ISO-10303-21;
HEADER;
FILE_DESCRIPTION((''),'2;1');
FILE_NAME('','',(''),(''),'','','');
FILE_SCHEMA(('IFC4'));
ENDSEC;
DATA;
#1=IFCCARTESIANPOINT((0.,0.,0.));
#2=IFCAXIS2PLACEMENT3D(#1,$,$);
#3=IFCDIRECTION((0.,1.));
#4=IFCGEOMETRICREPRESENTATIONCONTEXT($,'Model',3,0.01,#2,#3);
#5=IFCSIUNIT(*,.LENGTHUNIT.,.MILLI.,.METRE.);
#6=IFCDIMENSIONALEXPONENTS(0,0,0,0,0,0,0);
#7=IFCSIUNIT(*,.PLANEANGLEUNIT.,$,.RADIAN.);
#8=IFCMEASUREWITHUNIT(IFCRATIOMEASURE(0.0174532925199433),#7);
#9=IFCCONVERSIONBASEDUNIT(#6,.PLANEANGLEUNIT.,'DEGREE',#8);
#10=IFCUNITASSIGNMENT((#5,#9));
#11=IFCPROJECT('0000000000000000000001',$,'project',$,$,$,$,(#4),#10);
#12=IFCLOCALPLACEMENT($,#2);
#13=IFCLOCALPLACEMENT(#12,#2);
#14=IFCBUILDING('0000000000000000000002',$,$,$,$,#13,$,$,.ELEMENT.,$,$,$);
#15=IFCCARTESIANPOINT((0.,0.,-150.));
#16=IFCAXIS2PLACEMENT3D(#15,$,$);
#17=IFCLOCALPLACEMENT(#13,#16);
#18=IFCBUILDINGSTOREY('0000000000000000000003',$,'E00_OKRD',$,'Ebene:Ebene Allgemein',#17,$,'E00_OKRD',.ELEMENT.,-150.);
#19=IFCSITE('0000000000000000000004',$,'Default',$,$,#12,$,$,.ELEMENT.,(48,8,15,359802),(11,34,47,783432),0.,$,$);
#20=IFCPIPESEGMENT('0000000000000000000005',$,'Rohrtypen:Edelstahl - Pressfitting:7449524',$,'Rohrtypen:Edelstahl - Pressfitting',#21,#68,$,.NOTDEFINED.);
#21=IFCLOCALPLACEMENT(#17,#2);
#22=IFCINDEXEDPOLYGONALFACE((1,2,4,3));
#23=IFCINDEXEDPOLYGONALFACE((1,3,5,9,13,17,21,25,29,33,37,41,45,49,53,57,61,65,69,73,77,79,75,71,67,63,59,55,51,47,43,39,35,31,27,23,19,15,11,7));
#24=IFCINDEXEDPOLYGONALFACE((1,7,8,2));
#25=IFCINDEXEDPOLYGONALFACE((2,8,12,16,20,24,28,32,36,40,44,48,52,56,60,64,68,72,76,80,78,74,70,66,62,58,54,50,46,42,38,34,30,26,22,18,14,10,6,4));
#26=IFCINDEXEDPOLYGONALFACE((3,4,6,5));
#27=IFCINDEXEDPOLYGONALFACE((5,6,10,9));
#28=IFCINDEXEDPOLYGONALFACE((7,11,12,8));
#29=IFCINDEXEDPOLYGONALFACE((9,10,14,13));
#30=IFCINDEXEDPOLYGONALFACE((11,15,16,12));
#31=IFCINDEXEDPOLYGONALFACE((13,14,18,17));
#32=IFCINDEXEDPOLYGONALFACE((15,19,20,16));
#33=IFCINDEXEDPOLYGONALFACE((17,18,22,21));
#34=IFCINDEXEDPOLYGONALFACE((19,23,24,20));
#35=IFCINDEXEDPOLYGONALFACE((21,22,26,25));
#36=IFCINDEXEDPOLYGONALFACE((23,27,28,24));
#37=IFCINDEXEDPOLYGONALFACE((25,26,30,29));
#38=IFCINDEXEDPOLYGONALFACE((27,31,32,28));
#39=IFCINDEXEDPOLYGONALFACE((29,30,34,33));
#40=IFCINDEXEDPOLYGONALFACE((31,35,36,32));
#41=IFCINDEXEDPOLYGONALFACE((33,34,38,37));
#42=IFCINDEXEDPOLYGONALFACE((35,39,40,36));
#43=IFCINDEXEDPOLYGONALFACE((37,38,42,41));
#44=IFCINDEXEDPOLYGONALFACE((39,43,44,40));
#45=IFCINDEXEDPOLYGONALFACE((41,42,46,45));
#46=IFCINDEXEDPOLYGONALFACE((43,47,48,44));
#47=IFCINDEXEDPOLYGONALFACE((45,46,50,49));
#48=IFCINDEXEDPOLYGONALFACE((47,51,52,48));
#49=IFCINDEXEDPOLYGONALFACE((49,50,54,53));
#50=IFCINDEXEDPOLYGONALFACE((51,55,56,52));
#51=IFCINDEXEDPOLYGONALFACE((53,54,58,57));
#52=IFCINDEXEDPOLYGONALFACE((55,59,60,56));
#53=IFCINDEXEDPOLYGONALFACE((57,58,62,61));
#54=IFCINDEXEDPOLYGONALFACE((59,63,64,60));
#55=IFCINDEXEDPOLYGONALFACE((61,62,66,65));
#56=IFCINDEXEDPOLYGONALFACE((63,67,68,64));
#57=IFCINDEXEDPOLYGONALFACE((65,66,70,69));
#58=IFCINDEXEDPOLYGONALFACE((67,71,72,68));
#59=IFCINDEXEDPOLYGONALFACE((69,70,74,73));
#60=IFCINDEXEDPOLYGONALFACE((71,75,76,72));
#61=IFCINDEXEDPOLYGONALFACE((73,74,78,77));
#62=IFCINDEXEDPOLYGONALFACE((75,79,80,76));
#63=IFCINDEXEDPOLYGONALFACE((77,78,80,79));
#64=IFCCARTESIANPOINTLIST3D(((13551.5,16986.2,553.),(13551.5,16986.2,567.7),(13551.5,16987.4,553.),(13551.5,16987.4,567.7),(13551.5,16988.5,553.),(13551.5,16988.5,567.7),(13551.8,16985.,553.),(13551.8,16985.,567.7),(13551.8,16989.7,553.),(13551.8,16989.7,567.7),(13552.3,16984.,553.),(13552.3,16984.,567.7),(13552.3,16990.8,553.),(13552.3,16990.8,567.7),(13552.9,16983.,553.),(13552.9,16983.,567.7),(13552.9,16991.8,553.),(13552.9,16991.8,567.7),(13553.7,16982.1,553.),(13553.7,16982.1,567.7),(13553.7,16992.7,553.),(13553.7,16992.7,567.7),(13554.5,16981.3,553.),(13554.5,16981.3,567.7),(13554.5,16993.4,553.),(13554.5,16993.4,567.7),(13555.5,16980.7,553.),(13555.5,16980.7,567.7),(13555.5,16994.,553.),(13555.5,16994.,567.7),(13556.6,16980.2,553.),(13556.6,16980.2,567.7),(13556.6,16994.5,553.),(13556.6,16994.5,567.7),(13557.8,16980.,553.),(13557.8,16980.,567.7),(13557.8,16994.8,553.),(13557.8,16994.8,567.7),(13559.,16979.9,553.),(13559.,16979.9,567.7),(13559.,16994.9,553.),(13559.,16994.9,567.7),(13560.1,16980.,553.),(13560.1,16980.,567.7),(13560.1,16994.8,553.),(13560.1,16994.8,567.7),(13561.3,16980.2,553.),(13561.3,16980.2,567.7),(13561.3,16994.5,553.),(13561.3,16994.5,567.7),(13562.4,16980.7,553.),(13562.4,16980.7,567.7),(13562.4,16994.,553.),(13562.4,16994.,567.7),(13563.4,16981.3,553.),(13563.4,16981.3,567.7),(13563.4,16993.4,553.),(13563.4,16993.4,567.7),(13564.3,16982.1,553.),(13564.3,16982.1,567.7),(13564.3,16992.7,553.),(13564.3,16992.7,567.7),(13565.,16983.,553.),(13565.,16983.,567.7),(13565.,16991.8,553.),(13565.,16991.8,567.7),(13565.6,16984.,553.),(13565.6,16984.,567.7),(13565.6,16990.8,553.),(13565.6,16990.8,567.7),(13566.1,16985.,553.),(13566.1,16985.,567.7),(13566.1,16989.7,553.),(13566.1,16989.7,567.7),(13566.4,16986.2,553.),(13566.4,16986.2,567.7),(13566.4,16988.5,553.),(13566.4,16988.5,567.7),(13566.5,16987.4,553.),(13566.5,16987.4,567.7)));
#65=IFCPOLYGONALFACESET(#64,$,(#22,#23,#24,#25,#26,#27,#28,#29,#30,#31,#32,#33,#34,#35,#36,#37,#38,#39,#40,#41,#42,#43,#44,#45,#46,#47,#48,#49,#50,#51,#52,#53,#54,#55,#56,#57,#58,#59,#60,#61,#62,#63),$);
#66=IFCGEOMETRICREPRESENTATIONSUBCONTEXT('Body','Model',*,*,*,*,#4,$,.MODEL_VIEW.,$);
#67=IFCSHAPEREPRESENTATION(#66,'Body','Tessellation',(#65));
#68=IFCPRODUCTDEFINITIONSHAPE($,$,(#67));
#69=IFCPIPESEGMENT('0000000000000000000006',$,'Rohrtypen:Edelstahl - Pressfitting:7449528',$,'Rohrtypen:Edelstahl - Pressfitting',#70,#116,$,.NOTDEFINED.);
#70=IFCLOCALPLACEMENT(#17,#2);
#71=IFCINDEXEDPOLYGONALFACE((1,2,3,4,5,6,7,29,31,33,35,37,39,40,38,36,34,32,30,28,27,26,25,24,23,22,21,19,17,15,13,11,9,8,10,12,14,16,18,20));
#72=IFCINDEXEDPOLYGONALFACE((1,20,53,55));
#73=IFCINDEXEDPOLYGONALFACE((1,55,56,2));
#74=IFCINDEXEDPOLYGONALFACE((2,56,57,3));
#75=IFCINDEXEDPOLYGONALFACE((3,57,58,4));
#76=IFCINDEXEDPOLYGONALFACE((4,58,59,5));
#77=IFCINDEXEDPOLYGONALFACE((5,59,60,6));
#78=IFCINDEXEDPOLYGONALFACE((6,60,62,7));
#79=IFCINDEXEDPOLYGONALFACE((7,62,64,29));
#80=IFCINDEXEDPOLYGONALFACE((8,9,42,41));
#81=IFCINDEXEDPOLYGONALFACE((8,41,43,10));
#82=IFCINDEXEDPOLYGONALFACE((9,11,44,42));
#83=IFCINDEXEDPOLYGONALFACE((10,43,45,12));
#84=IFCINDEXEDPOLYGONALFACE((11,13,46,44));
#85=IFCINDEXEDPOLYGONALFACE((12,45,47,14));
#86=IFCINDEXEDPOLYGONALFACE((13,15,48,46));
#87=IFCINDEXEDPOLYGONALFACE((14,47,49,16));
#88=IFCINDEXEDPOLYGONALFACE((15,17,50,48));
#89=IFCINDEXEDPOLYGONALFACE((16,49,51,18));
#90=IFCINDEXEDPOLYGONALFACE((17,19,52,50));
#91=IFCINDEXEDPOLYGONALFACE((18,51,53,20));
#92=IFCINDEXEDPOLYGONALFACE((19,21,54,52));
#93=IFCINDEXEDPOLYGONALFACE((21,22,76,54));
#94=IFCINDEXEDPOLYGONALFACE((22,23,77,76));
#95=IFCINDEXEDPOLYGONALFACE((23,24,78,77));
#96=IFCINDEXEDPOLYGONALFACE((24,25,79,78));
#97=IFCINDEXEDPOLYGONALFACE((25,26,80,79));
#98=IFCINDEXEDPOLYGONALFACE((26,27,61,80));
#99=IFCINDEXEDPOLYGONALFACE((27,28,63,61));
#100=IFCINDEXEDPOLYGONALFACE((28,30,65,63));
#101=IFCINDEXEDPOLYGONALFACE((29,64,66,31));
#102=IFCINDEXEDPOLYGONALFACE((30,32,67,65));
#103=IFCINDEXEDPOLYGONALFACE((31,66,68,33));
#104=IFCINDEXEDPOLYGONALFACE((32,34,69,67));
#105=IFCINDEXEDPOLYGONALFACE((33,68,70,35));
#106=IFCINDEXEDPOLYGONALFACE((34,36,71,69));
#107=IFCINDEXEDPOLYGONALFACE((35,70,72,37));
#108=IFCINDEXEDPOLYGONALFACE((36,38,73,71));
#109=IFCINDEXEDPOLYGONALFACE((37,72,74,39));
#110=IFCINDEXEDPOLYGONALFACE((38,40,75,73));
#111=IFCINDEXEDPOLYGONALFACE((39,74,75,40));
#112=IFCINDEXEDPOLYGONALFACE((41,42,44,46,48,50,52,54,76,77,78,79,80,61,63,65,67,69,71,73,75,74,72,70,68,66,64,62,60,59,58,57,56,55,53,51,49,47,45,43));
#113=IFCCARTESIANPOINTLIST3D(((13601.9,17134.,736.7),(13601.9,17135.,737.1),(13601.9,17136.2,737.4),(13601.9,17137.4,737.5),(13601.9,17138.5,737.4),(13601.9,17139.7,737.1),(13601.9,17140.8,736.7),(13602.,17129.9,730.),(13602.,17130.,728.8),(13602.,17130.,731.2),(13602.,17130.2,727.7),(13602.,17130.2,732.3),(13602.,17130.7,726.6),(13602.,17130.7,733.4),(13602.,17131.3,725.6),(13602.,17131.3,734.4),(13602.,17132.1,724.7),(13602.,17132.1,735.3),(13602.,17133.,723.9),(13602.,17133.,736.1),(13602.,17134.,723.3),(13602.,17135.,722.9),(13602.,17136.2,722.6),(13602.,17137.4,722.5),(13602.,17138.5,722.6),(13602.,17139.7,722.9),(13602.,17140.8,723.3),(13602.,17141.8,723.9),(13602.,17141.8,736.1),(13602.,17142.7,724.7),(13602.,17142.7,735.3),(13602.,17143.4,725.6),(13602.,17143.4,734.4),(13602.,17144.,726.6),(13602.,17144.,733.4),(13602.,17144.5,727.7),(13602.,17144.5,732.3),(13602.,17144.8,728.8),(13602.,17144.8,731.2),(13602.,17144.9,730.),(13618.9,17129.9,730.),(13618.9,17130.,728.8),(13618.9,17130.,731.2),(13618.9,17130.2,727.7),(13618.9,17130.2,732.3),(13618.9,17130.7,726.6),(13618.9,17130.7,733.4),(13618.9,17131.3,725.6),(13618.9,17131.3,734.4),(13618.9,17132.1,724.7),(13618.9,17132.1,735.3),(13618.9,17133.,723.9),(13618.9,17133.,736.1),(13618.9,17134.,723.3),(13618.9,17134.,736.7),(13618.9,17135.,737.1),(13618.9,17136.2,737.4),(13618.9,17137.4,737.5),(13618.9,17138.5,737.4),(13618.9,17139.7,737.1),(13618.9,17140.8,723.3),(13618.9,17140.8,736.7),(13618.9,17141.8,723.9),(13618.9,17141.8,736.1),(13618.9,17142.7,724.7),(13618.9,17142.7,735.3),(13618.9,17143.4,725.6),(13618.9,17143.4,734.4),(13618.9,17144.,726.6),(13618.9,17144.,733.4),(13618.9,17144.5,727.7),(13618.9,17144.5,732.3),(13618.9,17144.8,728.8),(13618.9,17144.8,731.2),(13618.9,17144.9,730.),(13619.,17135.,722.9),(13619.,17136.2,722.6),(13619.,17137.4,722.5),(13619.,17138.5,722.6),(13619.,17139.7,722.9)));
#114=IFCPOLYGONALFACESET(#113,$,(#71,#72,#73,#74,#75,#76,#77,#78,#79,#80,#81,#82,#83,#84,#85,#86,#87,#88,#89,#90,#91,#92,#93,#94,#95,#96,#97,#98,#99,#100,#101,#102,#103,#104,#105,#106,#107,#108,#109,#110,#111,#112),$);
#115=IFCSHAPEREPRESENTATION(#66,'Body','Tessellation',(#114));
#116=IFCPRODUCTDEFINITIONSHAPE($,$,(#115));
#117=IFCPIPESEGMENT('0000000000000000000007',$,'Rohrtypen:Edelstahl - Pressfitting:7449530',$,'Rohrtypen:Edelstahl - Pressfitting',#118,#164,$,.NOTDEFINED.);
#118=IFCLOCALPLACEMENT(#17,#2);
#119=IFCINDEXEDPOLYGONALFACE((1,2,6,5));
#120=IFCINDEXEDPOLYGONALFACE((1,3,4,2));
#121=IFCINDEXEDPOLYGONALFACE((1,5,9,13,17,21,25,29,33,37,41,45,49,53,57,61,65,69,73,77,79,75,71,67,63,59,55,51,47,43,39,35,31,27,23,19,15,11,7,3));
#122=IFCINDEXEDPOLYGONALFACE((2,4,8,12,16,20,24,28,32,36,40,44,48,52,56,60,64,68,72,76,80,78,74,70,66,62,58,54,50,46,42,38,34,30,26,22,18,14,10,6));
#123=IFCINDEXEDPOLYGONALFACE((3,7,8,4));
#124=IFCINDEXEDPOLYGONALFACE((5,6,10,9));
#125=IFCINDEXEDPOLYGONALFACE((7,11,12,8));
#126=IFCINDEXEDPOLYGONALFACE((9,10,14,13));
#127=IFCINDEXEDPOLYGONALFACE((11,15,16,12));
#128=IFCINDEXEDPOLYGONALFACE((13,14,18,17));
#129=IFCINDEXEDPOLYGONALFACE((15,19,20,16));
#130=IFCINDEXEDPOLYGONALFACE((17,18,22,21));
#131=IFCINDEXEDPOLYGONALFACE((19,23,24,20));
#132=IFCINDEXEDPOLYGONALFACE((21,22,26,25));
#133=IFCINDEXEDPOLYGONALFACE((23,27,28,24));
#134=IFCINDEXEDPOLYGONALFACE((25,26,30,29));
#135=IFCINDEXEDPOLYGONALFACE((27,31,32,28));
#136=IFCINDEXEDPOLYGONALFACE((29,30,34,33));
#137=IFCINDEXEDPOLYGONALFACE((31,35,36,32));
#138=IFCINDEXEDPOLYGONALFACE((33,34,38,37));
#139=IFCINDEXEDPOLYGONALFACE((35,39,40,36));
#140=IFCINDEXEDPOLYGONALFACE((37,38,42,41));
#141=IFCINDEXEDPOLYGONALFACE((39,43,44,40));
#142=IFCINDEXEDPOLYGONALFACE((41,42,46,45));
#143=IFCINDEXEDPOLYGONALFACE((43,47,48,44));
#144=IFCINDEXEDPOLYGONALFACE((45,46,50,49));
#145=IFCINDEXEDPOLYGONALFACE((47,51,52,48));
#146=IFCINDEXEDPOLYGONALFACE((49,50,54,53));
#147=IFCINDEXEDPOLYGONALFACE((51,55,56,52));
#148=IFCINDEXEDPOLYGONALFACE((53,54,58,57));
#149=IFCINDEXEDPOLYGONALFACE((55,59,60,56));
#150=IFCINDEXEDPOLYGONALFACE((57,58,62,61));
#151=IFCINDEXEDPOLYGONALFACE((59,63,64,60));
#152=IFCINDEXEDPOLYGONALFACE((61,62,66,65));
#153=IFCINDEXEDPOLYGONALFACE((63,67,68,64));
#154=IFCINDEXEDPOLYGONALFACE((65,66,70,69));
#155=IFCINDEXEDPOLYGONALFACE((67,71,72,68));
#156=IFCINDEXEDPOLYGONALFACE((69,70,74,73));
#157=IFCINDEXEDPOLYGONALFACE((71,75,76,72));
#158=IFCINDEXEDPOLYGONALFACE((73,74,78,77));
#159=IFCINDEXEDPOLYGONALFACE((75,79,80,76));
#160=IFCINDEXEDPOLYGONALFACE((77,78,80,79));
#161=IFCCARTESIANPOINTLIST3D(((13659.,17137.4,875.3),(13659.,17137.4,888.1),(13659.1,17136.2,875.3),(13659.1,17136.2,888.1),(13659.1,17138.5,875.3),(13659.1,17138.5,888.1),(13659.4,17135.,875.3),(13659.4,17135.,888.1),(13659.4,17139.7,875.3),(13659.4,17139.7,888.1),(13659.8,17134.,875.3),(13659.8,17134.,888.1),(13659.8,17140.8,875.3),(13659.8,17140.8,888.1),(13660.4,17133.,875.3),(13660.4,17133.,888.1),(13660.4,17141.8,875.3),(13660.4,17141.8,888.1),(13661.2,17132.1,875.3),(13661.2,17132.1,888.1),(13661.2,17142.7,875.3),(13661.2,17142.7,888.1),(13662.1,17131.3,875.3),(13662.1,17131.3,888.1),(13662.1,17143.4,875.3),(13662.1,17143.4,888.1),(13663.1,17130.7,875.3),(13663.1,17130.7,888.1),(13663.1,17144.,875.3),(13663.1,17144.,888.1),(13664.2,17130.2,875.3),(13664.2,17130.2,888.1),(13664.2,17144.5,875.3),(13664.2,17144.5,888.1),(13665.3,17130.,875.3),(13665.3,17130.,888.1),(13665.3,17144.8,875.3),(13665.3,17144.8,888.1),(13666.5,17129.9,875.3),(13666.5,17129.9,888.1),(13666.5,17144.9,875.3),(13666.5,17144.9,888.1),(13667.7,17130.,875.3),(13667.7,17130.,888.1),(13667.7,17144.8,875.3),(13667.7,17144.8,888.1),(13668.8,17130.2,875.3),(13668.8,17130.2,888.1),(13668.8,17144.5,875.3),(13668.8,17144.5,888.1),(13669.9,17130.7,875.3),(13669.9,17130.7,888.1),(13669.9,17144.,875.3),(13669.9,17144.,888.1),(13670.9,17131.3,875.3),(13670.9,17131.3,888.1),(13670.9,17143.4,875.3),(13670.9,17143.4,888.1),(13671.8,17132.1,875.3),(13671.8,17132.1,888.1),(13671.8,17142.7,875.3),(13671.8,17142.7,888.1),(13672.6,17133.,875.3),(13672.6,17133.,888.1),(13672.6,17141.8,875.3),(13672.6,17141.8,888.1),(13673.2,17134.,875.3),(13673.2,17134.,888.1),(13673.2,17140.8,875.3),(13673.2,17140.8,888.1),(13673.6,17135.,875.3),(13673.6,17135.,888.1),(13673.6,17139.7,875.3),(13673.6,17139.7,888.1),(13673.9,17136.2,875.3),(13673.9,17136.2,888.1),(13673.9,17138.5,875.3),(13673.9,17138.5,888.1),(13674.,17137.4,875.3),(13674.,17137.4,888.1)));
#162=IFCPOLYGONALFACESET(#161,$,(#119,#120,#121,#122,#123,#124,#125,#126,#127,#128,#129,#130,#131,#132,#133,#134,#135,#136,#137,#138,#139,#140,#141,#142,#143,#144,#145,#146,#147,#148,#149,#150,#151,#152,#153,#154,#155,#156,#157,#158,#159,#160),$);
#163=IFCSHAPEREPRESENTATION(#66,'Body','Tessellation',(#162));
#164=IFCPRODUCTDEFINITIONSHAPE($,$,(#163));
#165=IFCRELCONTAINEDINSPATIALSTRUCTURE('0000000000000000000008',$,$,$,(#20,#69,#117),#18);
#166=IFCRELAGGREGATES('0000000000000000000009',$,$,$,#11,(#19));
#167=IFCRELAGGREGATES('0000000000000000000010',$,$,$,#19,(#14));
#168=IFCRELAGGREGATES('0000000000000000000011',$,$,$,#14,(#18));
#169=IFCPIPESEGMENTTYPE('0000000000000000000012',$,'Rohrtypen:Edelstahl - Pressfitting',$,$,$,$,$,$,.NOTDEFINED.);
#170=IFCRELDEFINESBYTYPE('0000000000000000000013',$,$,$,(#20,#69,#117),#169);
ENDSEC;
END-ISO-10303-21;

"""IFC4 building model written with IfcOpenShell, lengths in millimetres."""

from ifc_helpers import new_model, entity, si_unit, converted_unit, direction, frame, origin, place, context, subcontext, project, spatial, indexed_curve, outline, extrude, type_object, element, save


model = new_model("IFC4")

# Units and contexts
model_context = context("Model", 3, precision=0.01, world=origin(), true_north=direction((0.0, 1.0)))
body_context = subcontext(model_context, "Body", "Model", "MODEL_VIEW")
ifc_project = project(units=[si_unit("LENGTHUNIT", "METRE", prefix="MILLI"), converted_unit("PLANEANGLEUNIT", "DEGREE", entity("IfcRatioMeasure", 0.0174532925199433), si_unit("PLANEANGLEUNIT", "RADIAN"), dimensions=[0, 0, 0, 0, 0, 0, 0])], contexts=[model_context])

# Site, building, storey
site_placement = place(None, origin())
site = spatial("IfcSite", under=ifc_project, at=site_placement, Name="Default", CompositionType="ELEMENT", RefLatitude=(48, 8, 15, 359802), RefLongitude=(11, 34, 47, 783432), RefElevation=0.0)
building_placement = place(site_placement, origin())
building = spatial("IfcBuilding", under=site, at=building_placement, CompositionType="ELEMENT")
storey_placement = place(building_placement, frame((0.0, 0.0, -150.0)))
storey = spatial("IfcBuildingStorey", under=building, at=storey_placement, Name="E00_OKRD", ObjectType="Ebene:Ebene Allgemein", LongName="E00_OKRD", CompositionType="ELEMENT", Elevation=-150.0)

# Pipe segments
pipe_segment_type_1 = type_object("IfcPipeSegmentType", Name="Rohrtypen:Edelstahl - Pressfitting", PredefinedType="NOTDEFINED")
pipe_segment_1_placement = place(storey_placement, origin())
element("IfcPipeSegment", 1, at=pipe_segment_1_placement, inside=storey, type_object=pipe_segment_type_1, Name="Rohrtypen:Edelstahl - Pressfitting:7449524", ObjectType="Rohrtypen:Edelstahl - Pressfitting", PredefinedType="NOTDEFINED", context=body_context, shape_type="SweptSolid", body=[
    extrude(outline(indexed_curve([(7.5, 0.0), (7.4, 1.2), (7.1, 2.3), (6.7, 3.4), (6.1, 4.4), (5.3, 5.3), (4.4, 6.1), (3.4, 6.7), (2.3, 7.1), (1.2, 7.4), (0.0, 7.5), (-1.2, 7.4), (-2.3, 7.1), (-3.4, 6.7), (-4.4, 6.1), (-5.3, 5.3), (-6.1, 4.4), (-6.7, 3.4), (-7.1, 2.3), (-7.4, 1.2), (-7.5, 0.0), (-7.4, -1.2), (-7.1, -2.3), (-6.7, -3.4), (-6.1, -4.4), (-5.3, -5.3), (-4.4, -6.1), (-3.4, -6.7), (-2.3, -7.1), (-1.2, -7.4), (0.0, -7.5), (1.2, -7.4), (2.3, -7.1), (3.4, -6.7), (4.4, -6.1), (5.3, -5.3), (6.1, -4.4), (6.7, -3.4), (7.1, -2.3), (7.4, -1.2), (7.5, 0.0)], self_intersect=False)), frame((13559.0, 16987.4, 553.0)), (0.0, 0.0, 1.0), 14.7),
])
pipe_segment_2_placement = place(storey_placement, origin())
element("IfcPipeSegment", 2, at=pipe_segment_2_placement, inside=storey, type_object=pipe_segment_type_1, Name="Rohrtypen:Edelstahl - Pressfitting:7449528", ObjectType="Rohrtypen:Edelstahl - Pressfitting", PredefinedType="NOTDEFINED", context=body_context, shape_type="SweptSolid", body=[
    extrude(outline(indexed_curve([(7.5, 0.0), (7.4, 1.2), (7.1, 2.3), (6.7, 3.4), (6.1, 4.4), (5.3, 5.3), (4.4, 6.1), (3.4, 6.7), (2.3, 7.1), (1.2, 7.4), (0.0, 7.5), (-1.2, 7.4), (-2.3, 7.1), (-3.4, 6.7), (-4.4, 6.1), (-5.3, 5.3), (-6.1, 4.4), (-6.7, 3.4), (-7.1, 2.3), (-7.4, 1.2), (-7.5, 0.0), (-7.4, -1.2), (-7.1, -2.3), (-6.7, -3.4), (-6.1, -4.4), (-5.3, -5.3), (-4.4, -6.1), (-3.4, -6.7), (-2.3, -7.1), (-1.2, -7.4), (0.0, -7.5), (1.2, -7.4), (2.3, -7.1), (3.4, -6.7), (4.4, -6.1), (5.3, -5.3), (6.1, -4.4), (6.7, -3.4), (7.1, -2.3), (7.4, -1.2), (7.5, 0.0)], self_intersect=False)), frame((13602.0, 17137.4, 730.0), z_axis=(1.0, 0.0, 0.00053), x_axis=(0.0, -1.0, 0.0)), (0.0, 0.0, 1.0), 17.0),
])
pipe_segment_3_placement = place(storey_placement, origin())
element("IfcPipeSegment", 3, at=pipe_segment_3_placement, inside=storey, type_object=pipe_segment_type_1, Name="Rohrtypen:Edelstahl - Pressfitting:7449530", ObjectType="Rohrtypen:Edelstahl - Pressfitting", PredefinedType="NOTDEFINED", context=body_context, shape_type="SweptSolid", body=[
    extrude(outline(indexed_curve([(7.5, 0.0), (7.4, 1.2), (7.1, 2.3), (6.7, 3.4), (6.1, 4.4), (5.3, 5.3), (4.4, 6.1), (3.4, 6.7), (2.3, 7.1), (1.2, 7.4), (0.0, 7.5), (-1.2, 7.4), (-2.3, 7.1), (-3.4, 6.7), (-4.4, 6.1), (-5.3, 5.3), (-6.1, 4.4), (-6.7, 3.4), (-7.1, 2.3), (-7.4, 1.2), (-7.5, 0.0), (-7.4, -1.2), (-7.1, -2.3), (-6.7, -3.4), (-6.1, -4.4), (-5.3, -5.3), (-4.4, -6.1), (-3.4, -6.7), (-2.3, -7.1), (-1.2, -7.4), (0.0, -7.5), (1.2, -7.4), (2.3, -7.1), (3.4, -6.7), (4.4, -6.1), (5.3, -5.3), (6.1, -4.4), (6.7, -3.4), (7.1, -2.3), (7.4, -1.2), (7.5, 0.0)], self_intersect=False)), frame((13666.5, 17137.4, 875.3), z_axis=(0.0, 0.0, 1.0), x_axis=(-1.0, 0.0, 0.0)), (0.0, 0.0, 1.0), 12.8),
])

save(model, "model.ifc")
